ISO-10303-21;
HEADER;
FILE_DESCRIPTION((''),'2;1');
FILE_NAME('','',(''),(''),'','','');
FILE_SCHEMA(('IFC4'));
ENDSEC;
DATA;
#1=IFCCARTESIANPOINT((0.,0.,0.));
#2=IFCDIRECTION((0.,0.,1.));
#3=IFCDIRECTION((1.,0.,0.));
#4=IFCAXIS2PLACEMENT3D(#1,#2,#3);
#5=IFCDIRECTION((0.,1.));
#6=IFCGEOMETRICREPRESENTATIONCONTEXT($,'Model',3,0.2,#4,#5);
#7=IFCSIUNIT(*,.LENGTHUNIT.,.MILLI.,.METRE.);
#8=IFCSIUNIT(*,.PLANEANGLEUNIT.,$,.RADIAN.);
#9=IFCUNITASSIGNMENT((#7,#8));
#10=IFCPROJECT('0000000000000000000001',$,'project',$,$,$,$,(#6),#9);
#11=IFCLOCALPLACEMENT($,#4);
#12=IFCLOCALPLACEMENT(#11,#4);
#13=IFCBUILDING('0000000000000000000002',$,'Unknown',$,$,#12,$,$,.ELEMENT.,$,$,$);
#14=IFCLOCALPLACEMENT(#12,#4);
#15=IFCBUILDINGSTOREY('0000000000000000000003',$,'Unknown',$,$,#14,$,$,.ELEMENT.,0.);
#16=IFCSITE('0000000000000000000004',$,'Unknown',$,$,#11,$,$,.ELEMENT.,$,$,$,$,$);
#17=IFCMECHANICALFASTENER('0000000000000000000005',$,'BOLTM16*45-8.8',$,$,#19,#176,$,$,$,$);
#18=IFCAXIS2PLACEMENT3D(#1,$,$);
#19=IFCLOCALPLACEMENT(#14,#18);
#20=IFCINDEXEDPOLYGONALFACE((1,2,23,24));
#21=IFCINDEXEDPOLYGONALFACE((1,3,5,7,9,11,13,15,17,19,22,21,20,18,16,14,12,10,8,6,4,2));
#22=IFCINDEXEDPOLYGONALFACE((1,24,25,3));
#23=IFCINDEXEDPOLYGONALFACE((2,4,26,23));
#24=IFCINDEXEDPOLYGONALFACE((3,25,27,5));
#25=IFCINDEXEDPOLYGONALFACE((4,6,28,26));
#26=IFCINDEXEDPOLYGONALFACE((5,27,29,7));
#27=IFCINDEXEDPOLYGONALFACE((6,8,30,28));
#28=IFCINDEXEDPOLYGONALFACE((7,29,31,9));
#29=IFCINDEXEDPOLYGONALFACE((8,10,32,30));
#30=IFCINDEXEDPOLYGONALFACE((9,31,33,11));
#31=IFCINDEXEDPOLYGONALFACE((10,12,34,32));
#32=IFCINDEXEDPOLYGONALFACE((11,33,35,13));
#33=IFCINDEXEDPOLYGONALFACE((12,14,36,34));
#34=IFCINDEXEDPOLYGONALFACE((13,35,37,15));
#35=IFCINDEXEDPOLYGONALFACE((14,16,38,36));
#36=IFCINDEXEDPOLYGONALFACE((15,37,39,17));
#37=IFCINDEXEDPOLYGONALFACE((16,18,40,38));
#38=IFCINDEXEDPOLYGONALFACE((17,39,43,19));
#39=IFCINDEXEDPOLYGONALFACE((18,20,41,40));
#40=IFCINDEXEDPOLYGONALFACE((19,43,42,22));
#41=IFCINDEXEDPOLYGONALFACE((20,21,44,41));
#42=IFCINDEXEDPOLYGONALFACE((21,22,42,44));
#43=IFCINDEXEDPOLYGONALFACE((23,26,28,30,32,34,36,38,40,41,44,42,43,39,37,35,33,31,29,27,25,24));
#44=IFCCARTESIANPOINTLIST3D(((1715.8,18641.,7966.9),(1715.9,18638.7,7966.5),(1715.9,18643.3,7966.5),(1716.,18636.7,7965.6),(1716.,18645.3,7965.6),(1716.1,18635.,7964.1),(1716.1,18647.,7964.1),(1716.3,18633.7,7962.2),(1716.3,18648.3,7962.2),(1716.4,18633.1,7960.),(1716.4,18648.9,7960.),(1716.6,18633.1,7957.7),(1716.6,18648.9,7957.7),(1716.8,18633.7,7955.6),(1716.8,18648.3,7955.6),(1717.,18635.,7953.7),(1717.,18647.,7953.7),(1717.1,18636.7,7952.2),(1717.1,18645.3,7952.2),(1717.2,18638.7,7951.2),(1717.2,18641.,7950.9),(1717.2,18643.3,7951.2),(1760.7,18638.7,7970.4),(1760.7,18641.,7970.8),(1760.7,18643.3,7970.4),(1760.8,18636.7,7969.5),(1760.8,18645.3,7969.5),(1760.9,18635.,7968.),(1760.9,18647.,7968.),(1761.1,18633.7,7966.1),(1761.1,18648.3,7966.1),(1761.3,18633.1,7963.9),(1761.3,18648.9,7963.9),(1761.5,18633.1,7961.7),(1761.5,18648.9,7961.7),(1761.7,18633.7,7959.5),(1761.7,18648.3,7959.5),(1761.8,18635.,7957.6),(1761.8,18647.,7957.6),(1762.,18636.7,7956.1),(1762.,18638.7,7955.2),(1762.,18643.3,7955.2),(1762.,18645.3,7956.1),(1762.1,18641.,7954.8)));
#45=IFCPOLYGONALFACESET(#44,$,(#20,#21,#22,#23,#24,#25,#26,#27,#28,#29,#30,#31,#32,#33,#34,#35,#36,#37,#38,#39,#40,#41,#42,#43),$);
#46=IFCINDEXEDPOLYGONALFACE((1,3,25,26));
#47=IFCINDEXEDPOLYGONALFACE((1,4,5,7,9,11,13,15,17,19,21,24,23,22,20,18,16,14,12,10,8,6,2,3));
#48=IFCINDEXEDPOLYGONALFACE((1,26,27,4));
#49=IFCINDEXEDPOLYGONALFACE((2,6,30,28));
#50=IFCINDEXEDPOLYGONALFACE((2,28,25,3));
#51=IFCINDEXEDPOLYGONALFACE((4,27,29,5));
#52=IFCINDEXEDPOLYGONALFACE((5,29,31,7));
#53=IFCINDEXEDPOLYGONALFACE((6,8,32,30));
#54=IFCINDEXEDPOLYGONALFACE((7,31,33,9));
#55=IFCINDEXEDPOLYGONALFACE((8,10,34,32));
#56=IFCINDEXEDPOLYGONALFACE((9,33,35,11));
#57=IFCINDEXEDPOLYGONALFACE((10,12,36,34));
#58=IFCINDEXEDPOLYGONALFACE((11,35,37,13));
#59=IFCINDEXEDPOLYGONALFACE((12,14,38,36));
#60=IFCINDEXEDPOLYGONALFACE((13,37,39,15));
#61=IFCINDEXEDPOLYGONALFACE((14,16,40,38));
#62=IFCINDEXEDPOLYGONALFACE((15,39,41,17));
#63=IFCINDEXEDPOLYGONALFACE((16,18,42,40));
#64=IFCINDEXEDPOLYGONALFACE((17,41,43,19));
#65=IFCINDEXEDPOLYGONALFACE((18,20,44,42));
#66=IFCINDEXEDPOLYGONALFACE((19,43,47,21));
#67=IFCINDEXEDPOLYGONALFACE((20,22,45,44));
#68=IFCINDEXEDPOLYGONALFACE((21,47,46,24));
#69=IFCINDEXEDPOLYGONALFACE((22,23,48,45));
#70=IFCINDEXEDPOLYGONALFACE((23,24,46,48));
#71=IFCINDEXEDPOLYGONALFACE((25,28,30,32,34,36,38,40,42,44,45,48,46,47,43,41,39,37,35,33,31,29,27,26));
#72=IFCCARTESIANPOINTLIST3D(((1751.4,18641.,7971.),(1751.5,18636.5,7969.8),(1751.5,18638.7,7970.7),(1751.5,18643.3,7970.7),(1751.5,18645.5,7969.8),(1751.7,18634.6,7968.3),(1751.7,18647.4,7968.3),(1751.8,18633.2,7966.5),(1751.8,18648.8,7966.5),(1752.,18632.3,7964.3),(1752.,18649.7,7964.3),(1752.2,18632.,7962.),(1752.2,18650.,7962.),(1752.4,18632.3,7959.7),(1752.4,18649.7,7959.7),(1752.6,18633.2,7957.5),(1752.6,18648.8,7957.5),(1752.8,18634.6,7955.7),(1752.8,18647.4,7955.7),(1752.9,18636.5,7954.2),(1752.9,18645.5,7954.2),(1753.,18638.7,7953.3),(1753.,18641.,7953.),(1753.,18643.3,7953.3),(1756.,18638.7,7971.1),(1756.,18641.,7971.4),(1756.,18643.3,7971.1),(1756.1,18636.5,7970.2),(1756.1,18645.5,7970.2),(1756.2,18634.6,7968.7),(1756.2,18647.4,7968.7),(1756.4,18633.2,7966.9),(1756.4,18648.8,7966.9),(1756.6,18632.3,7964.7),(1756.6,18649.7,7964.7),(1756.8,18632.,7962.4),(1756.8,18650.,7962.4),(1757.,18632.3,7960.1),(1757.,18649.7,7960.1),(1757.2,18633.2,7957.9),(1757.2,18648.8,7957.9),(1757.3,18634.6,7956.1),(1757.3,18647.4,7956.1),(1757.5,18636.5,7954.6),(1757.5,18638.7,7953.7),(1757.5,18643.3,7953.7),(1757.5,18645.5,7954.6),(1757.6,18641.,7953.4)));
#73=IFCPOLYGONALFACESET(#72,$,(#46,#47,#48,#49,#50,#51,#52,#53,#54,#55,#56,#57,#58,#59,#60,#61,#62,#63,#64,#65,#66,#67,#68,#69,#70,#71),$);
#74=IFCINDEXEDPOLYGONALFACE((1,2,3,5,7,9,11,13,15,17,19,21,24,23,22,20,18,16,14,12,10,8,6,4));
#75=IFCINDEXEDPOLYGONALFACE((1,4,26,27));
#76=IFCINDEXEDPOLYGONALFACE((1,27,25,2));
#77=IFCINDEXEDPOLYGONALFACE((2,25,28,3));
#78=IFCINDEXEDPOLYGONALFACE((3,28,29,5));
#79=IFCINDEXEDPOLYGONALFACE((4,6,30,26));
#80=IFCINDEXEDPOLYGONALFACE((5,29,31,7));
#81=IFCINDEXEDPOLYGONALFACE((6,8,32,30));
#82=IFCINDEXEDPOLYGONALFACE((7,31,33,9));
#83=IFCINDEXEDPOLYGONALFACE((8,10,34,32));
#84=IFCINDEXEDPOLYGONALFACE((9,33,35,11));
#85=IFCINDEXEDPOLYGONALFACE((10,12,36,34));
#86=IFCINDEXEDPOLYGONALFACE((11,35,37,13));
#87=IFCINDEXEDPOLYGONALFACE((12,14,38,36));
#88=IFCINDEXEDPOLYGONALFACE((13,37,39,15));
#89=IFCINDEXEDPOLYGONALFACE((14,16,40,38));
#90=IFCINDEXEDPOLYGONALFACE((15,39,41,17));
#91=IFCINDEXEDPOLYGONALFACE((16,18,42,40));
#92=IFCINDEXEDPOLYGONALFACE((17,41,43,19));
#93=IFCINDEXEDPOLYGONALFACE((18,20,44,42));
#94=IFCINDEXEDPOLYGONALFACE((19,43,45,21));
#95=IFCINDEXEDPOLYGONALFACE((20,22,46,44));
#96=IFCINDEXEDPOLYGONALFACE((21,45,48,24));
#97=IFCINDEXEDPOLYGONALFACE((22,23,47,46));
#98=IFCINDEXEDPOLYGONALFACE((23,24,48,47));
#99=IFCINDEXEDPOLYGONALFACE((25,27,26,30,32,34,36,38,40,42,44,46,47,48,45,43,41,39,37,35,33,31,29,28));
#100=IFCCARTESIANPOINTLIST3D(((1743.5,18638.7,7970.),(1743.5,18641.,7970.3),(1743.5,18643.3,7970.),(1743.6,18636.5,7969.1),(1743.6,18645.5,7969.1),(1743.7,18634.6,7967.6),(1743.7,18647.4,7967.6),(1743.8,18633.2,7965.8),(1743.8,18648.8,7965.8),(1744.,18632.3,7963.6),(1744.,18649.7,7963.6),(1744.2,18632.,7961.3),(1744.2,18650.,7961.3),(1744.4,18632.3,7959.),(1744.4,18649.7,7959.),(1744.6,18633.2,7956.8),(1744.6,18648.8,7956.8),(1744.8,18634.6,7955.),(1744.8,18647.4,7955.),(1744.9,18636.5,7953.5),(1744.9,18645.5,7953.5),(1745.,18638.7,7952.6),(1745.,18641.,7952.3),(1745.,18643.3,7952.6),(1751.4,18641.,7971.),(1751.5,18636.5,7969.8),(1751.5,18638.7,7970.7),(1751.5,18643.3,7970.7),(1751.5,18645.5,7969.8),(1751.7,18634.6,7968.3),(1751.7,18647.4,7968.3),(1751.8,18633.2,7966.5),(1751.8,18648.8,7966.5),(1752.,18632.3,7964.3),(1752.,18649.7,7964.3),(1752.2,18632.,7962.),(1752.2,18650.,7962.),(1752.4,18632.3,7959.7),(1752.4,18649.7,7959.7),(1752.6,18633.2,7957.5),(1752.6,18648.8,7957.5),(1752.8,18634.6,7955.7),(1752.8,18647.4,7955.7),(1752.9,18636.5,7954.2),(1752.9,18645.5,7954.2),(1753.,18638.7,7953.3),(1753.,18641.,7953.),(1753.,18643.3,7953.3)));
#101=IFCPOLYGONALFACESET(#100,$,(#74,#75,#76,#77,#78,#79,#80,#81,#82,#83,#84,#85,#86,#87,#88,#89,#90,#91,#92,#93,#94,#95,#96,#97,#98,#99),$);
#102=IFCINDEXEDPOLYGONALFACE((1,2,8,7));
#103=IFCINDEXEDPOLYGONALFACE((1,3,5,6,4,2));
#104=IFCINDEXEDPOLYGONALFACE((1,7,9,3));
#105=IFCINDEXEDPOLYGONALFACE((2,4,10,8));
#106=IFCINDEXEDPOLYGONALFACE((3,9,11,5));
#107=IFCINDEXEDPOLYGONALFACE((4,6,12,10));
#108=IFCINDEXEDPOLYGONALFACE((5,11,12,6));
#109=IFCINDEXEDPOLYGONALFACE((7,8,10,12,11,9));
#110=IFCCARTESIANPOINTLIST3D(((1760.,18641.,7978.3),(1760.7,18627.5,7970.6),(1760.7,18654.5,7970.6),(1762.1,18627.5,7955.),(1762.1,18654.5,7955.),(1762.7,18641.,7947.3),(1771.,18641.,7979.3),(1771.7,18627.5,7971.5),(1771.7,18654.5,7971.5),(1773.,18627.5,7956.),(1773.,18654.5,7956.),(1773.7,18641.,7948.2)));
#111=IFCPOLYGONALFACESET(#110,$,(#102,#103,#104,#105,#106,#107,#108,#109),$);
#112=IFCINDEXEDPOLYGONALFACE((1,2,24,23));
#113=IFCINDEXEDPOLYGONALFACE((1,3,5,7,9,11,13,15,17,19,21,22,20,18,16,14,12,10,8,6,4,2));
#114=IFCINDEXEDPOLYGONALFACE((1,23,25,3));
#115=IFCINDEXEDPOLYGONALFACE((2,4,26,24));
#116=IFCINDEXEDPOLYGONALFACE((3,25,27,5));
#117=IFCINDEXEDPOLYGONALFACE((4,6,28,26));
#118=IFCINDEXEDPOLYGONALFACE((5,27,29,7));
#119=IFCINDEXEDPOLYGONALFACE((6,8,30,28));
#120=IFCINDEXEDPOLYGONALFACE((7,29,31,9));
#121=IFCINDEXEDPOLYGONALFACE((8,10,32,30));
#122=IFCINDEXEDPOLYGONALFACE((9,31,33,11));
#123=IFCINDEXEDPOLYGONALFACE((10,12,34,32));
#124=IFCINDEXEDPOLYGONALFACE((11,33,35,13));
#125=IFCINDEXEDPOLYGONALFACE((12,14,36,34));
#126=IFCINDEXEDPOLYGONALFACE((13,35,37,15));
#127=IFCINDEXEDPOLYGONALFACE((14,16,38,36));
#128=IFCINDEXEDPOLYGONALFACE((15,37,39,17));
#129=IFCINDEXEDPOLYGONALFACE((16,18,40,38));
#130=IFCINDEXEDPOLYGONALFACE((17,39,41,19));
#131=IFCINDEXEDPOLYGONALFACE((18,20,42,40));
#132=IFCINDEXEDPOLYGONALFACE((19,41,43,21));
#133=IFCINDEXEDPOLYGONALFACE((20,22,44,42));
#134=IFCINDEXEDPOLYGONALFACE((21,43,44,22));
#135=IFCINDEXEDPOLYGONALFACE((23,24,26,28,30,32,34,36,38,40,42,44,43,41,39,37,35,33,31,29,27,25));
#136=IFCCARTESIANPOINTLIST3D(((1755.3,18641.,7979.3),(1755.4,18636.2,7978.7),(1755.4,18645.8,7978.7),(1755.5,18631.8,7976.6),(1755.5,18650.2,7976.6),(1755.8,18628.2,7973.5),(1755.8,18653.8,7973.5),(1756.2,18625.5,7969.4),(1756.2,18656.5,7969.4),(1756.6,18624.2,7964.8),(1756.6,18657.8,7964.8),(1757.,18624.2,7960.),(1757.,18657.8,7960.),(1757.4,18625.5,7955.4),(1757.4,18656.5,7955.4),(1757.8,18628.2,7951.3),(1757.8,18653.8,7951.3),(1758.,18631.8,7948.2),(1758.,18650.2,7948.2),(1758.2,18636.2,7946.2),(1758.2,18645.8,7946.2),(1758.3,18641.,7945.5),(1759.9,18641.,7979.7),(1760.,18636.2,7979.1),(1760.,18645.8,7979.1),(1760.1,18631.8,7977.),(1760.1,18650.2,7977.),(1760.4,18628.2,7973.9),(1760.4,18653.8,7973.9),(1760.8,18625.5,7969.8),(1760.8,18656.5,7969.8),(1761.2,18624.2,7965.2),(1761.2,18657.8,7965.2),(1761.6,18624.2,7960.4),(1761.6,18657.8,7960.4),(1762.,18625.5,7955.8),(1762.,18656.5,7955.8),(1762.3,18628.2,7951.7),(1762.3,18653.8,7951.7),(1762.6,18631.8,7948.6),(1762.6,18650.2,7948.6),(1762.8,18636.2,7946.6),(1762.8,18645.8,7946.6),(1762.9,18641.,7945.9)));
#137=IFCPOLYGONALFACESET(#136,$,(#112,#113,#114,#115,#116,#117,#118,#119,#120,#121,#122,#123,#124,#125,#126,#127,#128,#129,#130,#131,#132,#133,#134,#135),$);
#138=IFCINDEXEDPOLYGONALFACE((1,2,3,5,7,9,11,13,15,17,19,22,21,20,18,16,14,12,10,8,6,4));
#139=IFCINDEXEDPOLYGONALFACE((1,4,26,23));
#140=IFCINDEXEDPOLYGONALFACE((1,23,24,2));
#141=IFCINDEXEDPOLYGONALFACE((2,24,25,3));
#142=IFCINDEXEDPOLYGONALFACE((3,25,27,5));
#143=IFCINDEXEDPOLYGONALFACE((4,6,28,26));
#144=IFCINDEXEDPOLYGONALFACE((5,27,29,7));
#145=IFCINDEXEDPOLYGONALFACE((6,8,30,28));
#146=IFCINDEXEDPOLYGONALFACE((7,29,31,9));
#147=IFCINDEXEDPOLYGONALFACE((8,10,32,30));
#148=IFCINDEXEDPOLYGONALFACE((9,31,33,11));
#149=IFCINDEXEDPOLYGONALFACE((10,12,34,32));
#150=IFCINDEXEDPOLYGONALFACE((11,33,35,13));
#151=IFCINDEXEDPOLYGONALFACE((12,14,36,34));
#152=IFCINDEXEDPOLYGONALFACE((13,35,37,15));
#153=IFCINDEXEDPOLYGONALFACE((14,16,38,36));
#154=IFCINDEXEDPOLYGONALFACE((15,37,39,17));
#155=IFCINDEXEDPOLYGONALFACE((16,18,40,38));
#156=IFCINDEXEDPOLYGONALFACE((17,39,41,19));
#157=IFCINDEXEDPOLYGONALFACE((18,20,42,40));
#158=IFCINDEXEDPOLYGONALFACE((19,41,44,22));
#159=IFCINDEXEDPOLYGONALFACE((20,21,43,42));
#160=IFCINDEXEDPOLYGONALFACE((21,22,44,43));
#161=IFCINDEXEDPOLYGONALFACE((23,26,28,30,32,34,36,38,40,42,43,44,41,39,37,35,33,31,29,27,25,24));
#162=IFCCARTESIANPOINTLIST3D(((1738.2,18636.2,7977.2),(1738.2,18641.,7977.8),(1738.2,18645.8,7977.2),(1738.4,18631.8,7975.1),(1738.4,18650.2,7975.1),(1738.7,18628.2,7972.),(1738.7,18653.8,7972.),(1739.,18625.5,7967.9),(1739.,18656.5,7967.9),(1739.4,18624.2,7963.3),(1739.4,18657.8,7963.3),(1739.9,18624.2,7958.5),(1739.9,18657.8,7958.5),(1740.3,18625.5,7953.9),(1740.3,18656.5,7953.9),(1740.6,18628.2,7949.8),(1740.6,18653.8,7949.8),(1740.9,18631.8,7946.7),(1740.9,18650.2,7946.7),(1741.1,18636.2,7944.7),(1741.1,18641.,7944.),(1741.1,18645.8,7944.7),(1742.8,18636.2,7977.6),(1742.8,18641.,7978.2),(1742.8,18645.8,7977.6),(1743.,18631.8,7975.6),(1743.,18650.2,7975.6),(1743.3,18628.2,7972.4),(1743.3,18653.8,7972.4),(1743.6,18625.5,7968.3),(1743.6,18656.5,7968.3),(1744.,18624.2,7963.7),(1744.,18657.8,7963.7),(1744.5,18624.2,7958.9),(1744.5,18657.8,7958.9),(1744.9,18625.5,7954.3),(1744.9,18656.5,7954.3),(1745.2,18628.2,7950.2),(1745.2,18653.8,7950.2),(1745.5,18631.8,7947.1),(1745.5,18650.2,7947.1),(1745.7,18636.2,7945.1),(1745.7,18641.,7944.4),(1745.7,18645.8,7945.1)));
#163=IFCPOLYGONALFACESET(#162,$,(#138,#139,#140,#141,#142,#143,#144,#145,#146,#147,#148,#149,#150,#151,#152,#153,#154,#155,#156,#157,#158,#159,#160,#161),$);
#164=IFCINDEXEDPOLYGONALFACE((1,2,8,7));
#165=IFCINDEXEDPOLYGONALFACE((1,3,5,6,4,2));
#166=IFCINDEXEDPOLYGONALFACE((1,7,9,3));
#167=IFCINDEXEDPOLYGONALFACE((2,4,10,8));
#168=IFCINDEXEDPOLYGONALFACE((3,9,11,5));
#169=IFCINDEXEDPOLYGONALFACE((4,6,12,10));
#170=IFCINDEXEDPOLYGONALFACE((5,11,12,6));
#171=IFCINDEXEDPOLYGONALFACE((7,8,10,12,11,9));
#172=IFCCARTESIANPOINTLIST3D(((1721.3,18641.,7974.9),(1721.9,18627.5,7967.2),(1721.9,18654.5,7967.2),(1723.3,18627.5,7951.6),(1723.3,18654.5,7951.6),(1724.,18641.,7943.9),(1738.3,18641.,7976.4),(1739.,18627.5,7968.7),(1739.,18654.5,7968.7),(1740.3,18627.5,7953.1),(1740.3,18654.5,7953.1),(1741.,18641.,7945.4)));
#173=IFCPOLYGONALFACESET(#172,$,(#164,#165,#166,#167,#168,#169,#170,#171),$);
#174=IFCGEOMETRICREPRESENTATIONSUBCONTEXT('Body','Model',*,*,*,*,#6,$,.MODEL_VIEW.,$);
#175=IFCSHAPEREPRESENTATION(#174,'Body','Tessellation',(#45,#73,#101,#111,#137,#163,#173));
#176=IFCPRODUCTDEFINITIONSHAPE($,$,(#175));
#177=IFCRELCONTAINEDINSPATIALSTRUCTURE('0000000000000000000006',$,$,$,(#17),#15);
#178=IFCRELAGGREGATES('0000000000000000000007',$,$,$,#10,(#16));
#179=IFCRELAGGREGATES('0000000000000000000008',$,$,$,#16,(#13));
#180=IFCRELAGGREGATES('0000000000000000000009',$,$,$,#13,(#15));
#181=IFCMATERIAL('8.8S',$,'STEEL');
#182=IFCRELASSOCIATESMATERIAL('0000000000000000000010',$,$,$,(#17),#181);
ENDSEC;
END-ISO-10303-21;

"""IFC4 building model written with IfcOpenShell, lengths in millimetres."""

from ifc_helpers import new_model, si_unit, direction, frame, origin_with_axes, place, context, subcontext, project, spatial, line, arc, indexed_curve, outline, extrude, source, transform, mapped, material, element, save


model = new_model("IFC4")

# Units and contexts
model_context = context("Model", 3, precision=0.2, world=origin_with_axes(), true_north=direction((0.0, 1.0)))
body_context = subcontext(model_context, "Body", "Model", "MODEL_VIEW")
ifc_project = project(units=[si_unit("LENGTHUNIT", "METRE", prefix="MILLI"), si_unit("PLANEANGLEUNIT", "RADIAN")], contexts=[model_context])

# Site, building, storey
site_placement = place(None, origin_with_axes())
site = spatial("IfcSite", under=ifc_project, at=site_placement, Name="Unknown", CompositionType="ELEMENT")
building_placement = place(site_placement, origin_with_axes())
building = spatial("IfcBuilding", under=site, at=building_placement, Name="Unknown", CompositionType="ELEMENT")
storey_placement = place(building_placement, origin_with_axes())
storey = spatial("IfcBuildingStorey", under=building, at=storey_placement, Name="Unknown", CompositionType="ELEMENT", Elevation=0.0)

# Mechanical fastener
ifc_material_1 = material(Name="8.8S", Category="STEEL")
shared_shape_1 = source(origin_with_axes(), body_context, "Body", "SweptSolid", [
    extrude(outline(indexed_curve([(8.0, 0.0), (0.0, 8.0), (-8.0, 0.0), (0.0, -8.0)], segments=[arc(1, 2, 3), arc(3, 4, 1)])), frame((0.0, 0.0, 9.2), z_axis=(0.0, 0.0, -1.0), x_axis=(0.0, 1.0, 0.0)), (0.0, 0.0, 1.0), 45.0),
    extrude(outline(indexed_curve([(0.0, 9.0), (6.4, 6.4), (9.0, 0.0), (6.4, -6.4), (0.0, -9.0), (-0.8, -9.0), (-9.0, 0.0), (-6.4, 6.4)], segments=[arc(1, 2, 3), arc(3, 4, 5), arc(5, 6, 7), arc(7, 8, 1)])), frame((0.0, 0.0, 4.6), z_axis=(0.0, 0.0, -1.0), x_axis=(0.0, 1.0, 0.0)), (0.0, 0.0, 1.0), 4.6),
    extrude(outline(indexed_curve([(0.0, 9.0), (6.4, 6.4), (9.0, 0.0), (6.4, -6.4), (0.0, -9.0), (-0.8, -9.0), (-9.0, 0.0), (-6.4, 6.4)], segments=[arc(1, 2, 3), arc(3, 4, 5), arc(5, 6, 7), arc(7, 8, 1)])), frame((0.0, 0.0, 0.0), z_axis=(0.0, 0.0, -1.0), x_axis=(0.0, 1.0, 0.0)), (0.0, 0.0, 1.0), 8.0),
    extrude(outline(indexed_curve([(15.6, 0.0), (7.8, 13.5), (-7.8, 13.5), (-15.6, 0.0), (-7.8, -13.5), (7.8, -13.5)], segments=[line(1, 2, 3, 4, 5, 6, 1)])), frame((0.0, 0.0, 20.2), z_axis=(0.0, 0.0, -1.0), x_axis=(0.0, 1.0, 0.0)), (0.0, 0.0, 1.0), 11.0),
    extrude(outline(indexed_curve([(17.0, 0.0), (0.0, 17.0), (-17.0, 0.0), (0.0, -17.0)], segments=[arc(1, 2, 3), arc(3, 4, 1)])), frame((0.0, 0.0, 9.2), z_axis=(0.0, 0.0, -1.0), x_axis=(0.0, 1.0, 0.0)), (0.0, 0.0, 1.0), 4.6),
    extrude(outline(indexed_curve([(17.0, 0.0), (0.0, 17.0), (-17.0, 0.0), (0.0, -17.0)], segments=[arc(1, 2, 3), arc(3, 4, 1)])), frame((0.0, 0.0, -8.0), z_axis=(0.0, 0.0, -1.0), x_axis=(0.0, 1.0, 0.0)), (0.0, 0.0, 1.0), 4.6),
    extrude(outline(indexed_curve([(15.6, 0.0), (7.8, 13.5), (-7.8, 13.5), (-15.6, 0.0), (-7.8, -13.5), (7.8, -13.5)], segments=[line(1, 2, 3, 4, 5, 6, 1)])), frame((0.0, 0.0, -12.6), z_axis=(0.0, 0.0, -1.0), x_axis=(0.0, 1.0, 0.0)), (0.0, 0.0, 1.0), 17.1),
])
mechanical_fastener_1_placement = place(storey_placement, frame((1752.2, 18641.0, 7962.0), z_axis=(0.996195, 0.0, 0.087156), x_axis=(0.0, 1.0, 0.0)))
element("IfcMechanicalFastener", 1, at=mechanical_fastener_1_placement, inside=storey, material=ifc_material_1, Name="BOLTM16*45-8.8", context=body_context, shape_type="MappedRepresentation", body=[
    mapped(shared_shape_1, transform((0.0, 0.0, 0.0))),
])

save(model, "model.ifc")
